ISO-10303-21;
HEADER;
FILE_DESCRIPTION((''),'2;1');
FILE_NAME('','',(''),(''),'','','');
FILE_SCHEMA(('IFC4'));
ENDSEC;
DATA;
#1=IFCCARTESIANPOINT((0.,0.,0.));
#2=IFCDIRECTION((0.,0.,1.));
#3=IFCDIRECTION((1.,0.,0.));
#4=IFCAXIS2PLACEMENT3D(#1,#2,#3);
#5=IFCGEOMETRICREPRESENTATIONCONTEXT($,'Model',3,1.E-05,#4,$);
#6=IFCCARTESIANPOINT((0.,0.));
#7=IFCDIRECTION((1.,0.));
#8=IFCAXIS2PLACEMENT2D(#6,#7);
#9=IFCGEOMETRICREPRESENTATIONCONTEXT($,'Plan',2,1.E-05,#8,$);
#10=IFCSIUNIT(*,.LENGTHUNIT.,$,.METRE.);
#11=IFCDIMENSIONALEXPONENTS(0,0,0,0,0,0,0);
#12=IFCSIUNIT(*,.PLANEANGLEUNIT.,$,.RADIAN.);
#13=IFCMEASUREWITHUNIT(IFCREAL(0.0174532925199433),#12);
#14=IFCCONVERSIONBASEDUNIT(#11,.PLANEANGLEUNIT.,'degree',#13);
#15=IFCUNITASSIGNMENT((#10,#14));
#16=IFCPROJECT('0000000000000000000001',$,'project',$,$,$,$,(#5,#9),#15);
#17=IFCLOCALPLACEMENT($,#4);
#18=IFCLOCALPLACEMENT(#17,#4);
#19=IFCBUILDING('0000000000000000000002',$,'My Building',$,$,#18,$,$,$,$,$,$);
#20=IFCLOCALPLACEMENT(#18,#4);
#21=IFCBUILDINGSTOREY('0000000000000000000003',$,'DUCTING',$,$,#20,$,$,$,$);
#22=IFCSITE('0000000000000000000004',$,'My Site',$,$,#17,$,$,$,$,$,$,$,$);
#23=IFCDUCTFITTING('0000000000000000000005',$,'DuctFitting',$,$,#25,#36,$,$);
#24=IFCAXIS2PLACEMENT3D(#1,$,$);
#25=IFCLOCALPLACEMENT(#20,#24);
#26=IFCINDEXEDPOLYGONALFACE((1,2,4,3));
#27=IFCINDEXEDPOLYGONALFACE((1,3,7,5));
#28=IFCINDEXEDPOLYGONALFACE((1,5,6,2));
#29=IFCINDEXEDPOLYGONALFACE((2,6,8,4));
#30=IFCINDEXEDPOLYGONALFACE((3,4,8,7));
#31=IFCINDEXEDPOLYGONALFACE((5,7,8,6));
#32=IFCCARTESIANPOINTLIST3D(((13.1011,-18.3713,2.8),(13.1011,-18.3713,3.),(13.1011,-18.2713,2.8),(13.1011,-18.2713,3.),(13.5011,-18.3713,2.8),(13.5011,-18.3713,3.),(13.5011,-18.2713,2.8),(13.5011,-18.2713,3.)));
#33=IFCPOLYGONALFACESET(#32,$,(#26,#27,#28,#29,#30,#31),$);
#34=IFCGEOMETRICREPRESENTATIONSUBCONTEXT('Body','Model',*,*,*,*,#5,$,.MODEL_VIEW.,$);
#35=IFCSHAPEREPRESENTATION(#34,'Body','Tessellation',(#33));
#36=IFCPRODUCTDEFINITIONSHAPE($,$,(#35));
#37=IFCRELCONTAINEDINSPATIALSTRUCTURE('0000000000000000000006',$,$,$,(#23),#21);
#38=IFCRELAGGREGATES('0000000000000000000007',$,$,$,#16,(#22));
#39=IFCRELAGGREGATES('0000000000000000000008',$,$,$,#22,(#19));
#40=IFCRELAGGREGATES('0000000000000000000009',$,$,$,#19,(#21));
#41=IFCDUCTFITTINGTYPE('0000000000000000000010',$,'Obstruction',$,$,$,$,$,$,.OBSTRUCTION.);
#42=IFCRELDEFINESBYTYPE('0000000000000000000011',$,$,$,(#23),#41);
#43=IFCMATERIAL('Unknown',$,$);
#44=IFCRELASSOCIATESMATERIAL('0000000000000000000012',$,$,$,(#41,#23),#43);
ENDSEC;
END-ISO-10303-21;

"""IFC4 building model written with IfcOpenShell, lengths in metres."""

from ifc_helpers import new_model, entity, si_unit, converted_unit, frame, origin_with_axes, origin_2d_with_axis, place, context, subcontext, project, spatial, rectangle, extrude, material, material_profile, profile_set, profile_usage, type_object, element, save


model = new_model("IFC4")

# Units and contexts
model_context = context("Model", 3, precision=1e-05, world=origin_with_axes())
plan_context = context("Plan", 2, precision=1e-05, world=origin_2d_with_axis())
body_context = subcontext(model_context, "Body", "Model", "MODEL_VIEW")
ifc_project = project(units=[si_unit("LENGTHUNIT", "METRE"), converted_unit("PLANEANGLEUNIT", "degree", entity("IfcReal", 0.0174532925199433), si_unit("PLANEANGLEUNIT", "RADIAN"), dimensions=[0, 0, 0, 0, 0, 0, 0])], contexts=[model_context, plan_context])

# Site, building, storey
site_placement = place(None, origin_with_axes())
site = spatial("IfcSite", under=ifc_project, at=site_placement, Name="My Site")
building_placement = place(site_placement, origin_with_axes())
building = spatial("IfcBuilding", under=site, at=building_placement, Name="My Building")
storey_placement = place(building_placement, origin_with_axes())
storey = spatial("IfcBuildingStorey", under=building, at=storey_placement, Name="DUCTING")

# Shared definitions
ifc_material = material(Name="Unknown")

# Duct fitting
ifc_material_profile_1 = material_profile(ifc_material, rectangle(XDim=0.4, YDim=0.2))
ifc_profile_set_1 = profile_set([ifc_material_profile_1])
duct_fitting_type_1 = type_object("IfcDuctFittingType", Name="Obstruction", PredefinedType="OBSTRUCTION", material=ifc_profile_set_1)
ifc_profile_usage_1 = profile_usage(ifc_profile_set_1, cardinal=5)
duct_fitting_1_placement = place(storey_placement, frame((13.3011, -18.2713, 2.9), z_axis=(0.0, -1.0, 0.0), x_axis=(1.0, 0.0, 0.0)))
element("IfcDuctFitting", 1, at=duct_fitting_1_placement, inside=storey, type_object=duct_fitting_type_1, material=ifc_profile_usage_1, Name="DuctFitting", context=body_context, shape_type="SweptSolid", body=[
    extrude(rectangle(XDim=0.4, YDim=0.2), origin_with_axes(), (0.0, 0.0, 1.0), 0.1),
])

save(model, "model.ifc")
